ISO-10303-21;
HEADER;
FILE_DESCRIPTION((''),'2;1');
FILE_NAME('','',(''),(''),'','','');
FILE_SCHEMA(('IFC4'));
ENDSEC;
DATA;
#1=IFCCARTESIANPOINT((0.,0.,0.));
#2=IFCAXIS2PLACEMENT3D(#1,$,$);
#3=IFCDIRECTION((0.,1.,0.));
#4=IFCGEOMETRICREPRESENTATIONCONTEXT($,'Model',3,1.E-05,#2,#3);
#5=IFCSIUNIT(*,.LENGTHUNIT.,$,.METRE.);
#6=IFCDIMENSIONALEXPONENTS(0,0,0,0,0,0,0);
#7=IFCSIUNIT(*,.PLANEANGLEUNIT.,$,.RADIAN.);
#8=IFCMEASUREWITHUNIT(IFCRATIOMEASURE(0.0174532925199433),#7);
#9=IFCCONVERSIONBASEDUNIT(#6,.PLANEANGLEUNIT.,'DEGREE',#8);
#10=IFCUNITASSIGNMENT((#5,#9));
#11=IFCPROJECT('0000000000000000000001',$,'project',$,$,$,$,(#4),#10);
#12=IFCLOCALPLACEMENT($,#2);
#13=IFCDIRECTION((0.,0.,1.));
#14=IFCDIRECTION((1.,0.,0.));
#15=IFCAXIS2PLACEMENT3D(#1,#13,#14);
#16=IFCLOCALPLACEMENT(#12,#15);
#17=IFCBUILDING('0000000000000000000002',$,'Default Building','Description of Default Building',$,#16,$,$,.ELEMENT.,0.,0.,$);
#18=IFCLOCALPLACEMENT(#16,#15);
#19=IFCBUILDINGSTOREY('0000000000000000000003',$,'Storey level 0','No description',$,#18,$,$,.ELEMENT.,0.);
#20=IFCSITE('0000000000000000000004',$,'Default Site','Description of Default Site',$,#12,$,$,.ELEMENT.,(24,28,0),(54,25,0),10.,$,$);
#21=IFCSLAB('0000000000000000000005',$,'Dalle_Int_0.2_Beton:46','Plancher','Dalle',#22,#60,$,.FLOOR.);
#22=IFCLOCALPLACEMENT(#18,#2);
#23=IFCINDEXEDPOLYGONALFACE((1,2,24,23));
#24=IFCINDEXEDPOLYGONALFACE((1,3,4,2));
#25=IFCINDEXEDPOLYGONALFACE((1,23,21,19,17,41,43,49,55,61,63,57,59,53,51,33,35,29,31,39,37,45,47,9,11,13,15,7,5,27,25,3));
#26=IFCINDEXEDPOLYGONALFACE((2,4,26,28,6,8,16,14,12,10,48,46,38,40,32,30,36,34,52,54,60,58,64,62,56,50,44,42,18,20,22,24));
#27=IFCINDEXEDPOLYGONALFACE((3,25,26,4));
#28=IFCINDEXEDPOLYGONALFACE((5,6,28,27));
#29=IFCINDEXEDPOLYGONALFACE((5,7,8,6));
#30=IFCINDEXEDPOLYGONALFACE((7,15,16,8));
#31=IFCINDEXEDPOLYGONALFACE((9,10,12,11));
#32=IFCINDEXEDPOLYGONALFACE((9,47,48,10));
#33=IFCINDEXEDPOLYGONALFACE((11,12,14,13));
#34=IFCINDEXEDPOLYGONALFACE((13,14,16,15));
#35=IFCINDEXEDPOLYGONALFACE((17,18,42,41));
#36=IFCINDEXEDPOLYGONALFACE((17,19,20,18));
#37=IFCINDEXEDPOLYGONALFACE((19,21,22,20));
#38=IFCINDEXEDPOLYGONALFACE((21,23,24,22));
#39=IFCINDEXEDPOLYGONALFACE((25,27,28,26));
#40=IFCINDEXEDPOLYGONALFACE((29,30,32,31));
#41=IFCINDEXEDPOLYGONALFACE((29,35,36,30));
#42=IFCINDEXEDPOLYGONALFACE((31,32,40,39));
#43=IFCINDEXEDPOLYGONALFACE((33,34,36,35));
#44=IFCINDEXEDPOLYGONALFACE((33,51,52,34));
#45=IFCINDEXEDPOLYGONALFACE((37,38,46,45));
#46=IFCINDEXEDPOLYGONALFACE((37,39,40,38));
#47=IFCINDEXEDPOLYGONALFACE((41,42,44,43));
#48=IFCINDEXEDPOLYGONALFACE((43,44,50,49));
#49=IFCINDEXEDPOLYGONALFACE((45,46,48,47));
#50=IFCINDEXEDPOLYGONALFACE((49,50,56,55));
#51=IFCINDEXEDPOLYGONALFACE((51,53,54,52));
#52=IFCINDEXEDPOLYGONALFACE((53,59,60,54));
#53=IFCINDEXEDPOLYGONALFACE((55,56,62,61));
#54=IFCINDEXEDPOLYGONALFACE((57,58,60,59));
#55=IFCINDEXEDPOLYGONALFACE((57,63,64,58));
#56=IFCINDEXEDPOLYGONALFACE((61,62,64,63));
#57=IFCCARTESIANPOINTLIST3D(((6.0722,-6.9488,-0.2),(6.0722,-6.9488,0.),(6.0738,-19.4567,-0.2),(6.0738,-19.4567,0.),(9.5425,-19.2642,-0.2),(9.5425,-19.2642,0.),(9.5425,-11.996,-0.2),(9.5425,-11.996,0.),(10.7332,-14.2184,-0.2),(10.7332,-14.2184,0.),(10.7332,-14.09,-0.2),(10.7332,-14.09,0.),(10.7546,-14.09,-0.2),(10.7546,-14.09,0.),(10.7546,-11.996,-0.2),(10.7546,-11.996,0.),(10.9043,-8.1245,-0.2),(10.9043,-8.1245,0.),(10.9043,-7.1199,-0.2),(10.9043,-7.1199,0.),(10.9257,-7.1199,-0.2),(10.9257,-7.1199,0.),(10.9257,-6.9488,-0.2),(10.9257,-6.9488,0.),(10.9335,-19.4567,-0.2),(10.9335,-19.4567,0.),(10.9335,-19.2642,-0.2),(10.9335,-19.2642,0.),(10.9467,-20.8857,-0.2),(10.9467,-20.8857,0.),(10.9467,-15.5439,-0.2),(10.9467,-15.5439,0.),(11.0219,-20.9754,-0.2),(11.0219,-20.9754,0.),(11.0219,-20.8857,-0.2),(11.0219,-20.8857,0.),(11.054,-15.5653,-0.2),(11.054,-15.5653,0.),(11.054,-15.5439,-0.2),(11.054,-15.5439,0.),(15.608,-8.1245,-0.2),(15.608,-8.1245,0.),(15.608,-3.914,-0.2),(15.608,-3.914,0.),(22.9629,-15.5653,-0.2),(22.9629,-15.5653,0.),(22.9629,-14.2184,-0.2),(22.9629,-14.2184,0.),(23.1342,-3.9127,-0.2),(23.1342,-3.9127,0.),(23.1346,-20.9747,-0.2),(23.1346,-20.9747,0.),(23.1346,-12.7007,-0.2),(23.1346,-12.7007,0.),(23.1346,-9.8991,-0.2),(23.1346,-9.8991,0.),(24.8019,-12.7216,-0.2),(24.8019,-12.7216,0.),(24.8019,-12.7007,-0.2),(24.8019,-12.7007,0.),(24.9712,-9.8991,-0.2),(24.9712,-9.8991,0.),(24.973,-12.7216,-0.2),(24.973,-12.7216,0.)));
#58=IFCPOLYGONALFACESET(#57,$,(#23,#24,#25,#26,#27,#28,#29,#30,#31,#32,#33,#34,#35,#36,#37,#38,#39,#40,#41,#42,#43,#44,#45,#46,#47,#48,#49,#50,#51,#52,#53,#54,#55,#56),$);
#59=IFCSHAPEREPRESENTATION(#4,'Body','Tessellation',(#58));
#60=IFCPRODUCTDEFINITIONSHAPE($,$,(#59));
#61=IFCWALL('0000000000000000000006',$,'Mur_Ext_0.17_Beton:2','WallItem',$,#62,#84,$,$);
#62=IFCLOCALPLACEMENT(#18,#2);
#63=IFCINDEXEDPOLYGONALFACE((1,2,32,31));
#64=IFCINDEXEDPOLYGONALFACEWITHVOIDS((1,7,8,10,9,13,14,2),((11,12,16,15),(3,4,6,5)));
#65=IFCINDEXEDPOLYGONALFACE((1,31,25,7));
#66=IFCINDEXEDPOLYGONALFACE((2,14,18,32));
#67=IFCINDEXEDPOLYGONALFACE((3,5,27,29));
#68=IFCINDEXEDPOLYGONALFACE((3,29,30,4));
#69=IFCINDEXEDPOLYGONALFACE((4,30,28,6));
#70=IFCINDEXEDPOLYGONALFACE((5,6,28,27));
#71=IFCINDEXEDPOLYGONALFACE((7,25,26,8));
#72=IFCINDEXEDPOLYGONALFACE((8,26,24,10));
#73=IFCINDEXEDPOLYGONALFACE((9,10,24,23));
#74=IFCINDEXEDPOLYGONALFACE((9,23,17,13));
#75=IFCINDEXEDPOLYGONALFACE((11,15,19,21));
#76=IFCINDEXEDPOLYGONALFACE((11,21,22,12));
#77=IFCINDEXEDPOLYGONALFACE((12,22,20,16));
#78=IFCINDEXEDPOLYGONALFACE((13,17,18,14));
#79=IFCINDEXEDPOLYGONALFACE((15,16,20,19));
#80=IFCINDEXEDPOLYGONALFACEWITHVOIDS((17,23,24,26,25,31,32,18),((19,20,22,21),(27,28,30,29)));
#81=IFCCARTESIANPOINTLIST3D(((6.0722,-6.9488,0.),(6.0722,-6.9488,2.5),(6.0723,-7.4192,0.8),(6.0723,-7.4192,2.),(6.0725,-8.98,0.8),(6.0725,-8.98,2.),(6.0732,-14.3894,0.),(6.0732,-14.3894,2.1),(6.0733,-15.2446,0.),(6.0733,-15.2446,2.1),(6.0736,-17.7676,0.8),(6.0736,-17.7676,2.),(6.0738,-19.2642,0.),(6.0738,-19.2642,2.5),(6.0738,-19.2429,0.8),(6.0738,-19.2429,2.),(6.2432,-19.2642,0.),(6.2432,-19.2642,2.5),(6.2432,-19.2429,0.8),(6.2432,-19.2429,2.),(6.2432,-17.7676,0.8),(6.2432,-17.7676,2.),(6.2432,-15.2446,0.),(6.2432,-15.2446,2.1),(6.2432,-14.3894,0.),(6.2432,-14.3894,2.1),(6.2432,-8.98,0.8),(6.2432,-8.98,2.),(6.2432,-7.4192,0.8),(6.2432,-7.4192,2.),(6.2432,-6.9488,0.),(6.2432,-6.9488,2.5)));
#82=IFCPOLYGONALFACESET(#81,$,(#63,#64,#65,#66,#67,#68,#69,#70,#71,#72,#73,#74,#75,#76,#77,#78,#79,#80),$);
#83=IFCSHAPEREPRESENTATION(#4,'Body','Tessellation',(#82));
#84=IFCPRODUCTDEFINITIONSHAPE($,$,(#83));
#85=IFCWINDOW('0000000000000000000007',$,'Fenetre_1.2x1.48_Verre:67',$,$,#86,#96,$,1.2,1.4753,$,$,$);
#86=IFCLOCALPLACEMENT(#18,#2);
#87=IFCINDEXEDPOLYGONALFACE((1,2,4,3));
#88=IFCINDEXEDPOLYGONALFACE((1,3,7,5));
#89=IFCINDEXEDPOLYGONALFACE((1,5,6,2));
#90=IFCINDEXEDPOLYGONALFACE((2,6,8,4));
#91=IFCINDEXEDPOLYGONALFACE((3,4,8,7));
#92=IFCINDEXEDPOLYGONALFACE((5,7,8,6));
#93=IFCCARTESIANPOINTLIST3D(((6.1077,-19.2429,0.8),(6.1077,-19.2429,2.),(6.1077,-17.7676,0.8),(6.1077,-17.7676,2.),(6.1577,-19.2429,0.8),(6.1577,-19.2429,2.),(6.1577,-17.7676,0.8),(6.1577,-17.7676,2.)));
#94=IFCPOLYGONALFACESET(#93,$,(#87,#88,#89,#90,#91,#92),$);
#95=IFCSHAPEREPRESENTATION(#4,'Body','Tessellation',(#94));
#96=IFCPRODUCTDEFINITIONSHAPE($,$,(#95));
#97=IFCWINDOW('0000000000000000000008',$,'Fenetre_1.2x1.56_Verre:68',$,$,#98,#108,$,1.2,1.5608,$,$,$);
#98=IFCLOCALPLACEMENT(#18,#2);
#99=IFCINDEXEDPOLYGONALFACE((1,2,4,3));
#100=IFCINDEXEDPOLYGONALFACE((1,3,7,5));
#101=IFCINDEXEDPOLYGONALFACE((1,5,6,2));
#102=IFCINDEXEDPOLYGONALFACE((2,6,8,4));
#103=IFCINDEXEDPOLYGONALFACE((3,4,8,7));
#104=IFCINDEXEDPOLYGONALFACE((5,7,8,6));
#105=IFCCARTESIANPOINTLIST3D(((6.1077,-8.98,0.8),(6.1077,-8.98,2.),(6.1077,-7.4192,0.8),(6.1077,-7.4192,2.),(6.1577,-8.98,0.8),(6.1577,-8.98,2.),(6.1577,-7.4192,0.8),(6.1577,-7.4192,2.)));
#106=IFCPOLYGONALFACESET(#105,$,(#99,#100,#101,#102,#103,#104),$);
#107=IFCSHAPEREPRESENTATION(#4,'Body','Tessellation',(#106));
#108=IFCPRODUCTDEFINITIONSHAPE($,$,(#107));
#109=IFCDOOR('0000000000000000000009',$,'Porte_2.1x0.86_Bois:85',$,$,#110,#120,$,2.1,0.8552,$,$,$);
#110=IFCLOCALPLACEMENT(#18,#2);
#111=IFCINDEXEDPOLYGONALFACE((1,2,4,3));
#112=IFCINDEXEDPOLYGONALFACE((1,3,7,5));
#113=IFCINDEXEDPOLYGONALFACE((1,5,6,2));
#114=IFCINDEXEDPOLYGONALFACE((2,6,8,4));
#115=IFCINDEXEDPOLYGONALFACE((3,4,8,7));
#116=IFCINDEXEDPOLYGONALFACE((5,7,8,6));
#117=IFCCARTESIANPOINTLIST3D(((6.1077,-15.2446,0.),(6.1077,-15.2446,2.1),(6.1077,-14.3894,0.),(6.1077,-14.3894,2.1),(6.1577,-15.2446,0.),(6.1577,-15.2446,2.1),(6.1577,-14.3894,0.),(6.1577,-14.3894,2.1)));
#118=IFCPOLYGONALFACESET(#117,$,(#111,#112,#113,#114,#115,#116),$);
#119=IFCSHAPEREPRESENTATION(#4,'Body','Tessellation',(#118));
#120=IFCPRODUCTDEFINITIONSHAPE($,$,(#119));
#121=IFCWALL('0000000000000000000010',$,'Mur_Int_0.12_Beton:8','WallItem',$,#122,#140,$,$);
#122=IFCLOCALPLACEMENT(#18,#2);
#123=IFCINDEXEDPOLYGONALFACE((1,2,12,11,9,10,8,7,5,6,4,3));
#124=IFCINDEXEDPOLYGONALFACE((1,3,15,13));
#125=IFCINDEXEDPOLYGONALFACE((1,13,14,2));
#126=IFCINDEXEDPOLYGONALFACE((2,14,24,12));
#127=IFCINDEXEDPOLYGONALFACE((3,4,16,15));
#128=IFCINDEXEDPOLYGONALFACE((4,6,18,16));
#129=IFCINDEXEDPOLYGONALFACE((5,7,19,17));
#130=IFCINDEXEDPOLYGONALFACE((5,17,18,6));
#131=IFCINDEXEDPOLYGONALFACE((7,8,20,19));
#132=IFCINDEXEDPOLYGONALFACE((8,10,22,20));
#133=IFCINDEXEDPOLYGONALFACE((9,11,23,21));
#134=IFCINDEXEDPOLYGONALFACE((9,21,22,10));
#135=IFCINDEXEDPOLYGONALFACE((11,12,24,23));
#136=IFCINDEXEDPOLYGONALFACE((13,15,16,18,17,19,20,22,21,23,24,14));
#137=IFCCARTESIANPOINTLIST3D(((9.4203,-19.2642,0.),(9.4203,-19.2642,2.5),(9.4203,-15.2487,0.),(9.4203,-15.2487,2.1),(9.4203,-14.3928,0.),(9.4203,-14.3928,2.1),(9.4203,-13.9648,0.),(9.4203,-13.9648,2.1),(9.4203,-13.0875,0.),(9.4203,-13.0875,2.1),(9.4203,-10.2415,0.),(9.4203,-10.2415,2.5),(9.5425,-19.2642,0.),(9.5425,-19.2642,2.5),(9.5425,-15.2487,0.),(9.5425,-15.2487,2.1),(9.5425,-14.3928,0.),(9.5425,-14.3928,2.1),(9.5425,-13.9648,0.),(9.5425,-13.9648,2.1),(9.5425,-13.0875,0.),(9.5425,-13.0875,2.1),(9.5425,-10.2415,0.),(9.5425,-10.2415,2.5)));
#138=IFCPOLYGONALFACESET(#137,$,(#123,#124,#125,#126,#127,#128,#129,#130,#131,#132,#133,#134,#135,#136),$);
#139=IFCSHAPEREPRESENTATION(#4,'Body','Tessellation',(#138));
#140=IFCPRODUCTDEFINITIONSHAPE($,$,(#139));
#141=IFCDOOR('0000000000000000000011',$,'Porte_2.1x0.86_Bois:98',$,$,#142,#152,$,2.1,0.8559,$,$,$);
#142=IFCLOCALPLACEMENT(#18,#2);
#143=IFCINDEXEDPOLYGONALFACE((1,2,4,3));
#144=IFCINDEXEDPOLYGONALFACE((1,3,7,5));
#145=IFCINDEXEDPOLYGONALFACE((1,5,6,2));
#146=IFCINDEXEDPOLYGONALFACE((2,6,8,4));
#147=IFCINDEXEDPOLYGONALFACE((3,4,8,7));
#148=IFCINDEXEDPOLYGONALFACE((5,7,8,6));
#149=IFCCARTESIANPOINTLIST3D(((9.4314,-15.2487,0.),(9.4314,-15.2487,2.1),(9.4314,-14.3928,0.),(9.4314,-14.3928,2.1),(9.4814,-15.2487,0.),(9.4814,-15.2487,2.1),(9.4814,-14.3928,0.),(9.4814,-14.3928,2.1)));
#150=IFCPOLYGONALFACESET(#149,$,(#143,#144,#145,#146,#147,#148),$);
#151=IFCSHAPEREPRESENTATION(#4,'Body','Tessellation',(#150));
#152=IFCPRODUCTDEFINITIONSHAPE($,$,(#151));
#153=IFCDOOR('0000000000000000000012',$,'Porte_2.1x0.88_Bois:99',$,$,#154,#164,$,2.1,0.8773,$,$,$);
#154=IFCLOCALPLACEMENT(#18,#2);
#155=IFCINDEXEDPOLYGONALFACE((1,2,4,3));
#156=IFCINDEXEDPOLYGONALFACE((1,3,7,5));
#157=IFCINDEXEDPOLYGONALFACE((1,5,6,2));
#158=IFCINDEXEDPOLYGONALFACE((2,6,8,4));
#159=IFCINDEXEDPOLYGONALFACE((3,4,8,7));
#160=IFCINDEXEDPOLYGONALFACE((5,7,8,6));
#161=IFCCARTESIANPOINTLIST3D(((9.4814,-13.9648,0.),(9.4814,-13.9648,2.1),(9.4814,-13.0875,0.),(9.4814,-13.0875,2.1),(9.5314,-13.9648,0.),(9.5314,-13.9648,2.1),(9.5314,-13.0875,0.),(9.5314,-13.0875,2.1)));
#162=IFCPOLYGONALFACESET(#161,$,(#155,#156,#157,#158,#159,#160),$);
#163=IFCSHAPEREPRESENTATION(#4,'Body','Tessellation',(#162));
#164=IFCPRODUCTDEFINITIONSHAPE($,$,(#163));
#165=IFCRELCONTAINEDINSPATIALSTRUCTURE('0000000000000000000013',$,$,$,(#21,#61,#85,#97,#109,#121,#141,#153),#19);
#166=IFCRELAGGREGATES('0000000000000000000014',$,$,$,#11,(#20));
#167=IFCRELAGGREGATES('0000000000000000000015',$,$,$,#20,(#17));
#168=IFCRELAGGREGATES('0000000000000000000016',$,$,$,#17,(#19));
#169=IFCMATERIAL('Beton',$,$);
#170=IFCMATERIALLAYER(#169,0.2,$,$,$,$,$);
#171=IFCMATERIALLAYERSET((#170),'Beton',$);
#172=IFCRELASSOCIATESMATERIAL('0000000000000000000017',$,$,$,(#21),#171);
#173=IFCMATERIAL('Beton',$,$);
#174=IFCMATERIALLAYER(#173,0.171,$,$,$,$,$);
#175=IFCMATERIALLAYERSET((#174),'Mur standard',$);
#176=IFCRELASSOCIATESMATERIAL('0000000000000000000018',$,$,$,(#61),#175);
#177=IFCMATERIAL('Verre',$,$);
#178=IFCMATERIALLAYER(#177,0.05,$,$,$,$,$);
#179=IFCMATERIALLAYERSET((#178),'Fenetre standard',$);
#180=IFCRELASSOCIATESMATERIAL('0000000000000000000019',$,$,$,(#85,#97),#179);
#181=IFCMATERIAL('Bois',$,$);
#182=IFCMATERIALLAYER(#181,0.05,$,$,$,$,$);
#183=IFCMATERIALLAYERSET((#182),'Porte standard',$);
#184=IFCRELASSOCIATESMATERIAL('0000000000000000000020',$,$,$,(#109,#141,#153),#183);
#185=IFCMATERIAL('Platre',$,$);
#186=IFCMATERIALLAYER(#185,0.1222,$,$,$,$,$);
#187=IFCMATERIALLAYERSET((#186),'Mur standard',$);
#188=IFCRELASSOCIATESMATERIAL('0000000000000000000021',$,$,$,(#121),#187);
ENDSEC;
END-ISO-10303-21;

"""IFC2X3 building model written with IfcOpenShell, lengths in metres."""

from ifc_helpers import new_model, entity, si_unit, converted_unit, direction, frame, origin, origin_with_axes, place, context, project, spatial, polyline, outline, extrude, material, layer, layer_set, layer_usage, element, fill, save


model = new_model("IFC2X3")

# Units and contexts
model_context = context("Model", 3, precision=1e-05, world=origin(), true_north=direction((0.0, 1.0, 0.0)))
ifc_project = project(units=[si_unit("LENGTHUNIT", "METRE"), converted_unit("PLANEANGLEUNIT", "DEGREE", entity("IfcRatioMeasure", 0.0174532925199433), si_unit("PLANEANGLEUNIT", "RADIAN"), dimensions=[0, 0, 0, 0, 0, 0, 0])], contexts=[model_context])

# Site, building, storey
site_placement = place(None, origin())
site = spatial("IfcSite", under=ifc_project, at=site_placement, Name="Default Site", Description="Description of Default Site", CompositionType="ELEMENT", RefLatitude=(24, 28, 0), RefLongitude=(54, 25, 0), RefElevation=10.0)
building_placement = place(site_placement, origin_with_axes())
building = spatial("IfcBuilding", under=site, at=building_placement, Name="Default Building", Description="Description of Default Building", CompositionType="ELEMENT", ElevationOfRefHeight=0.0, ElevationOfTerrain=0.0)
storey_placement = place(building_placement, origin_with_axes())
storey = spatial("IfcBuildingStorey", under=building, at=storey_placement, Name="Storey level 0", Description="No description", CompositionType="ELEMENT", Elevation=0.0)

# Slab
ifc_material_1 = material(Name="Beton")
ifc_layer_1 = layer(ifc_material_1, 0.2)
ifc_layer_set_1 = layer_set([ifc_layer_1], Name="Beton")
ifc_layer_usage_1 = layer_usage(ifc_layer_set_1, "AXIS3", "POSITIVE", 0.2)
slab_placement = place(storey_placement, frame((0.0, 0.0, -0.2), z_axis=(0.0, 0.0, 1.0), x_axis=(1.0, 0.0, 0.0)))
element("IfcSlab", 1, at=slab_placement, inside=storey, material=ifc_layer_usage_1, Name="Dalle_Int_0.2_Beton:46", Description="Plancher", ObjectType="Dalle", PredefinedType="FLOOR", context=model_context, shape_type="SweptSolid", body=[
    extrude(outline(polyline([(23.1346, -9.8991), (24.9712, -9.8991), (24.973, -12.7216), (24.8019, -12.7216), (24.8019, -12.7007), (23.1346, -12.7007), (23.1346, -20.9747), (11.0219, -20.9754), (11.0219, -20.8857), (10.9467, -20.8857), (10.9467, -15.5439), (11.054, -15.5439), (11.054, -15.5653), (22.9629, -15.5653), (22.9629, -14.2184), (10.7332, -14.2184), (10.7332, -14.09), (10.7546, -14.09), (10.7546, -11.996), (9.5425, -11.996), (9.5425, -19.2642), (10.9335, -19.2642), (10.9335, -19.4567), (6.0738, -19.4567), (6.0722, -6.9488), (10.9257, -6.9488), (10.9257, -7.1199), (10.9043, -7.1199), (10.9043, -8.1245), (15.608, -8.1245), (15.608, -3.914), (23.1342, -3.9127), (23.1346, -9.8991)])), origin(), (0.0, 0.0, 1.0), 0.2),
])

# Wall, openings, windows, door
ifc_material_2 = material(Name="Beton")
ifc_layer_2 = layer(ifc_material_2, 0.171)
ifc_layer_set_2 = layer_set([ifc_layer_2], Name="Mur standard")
ifc_layer_usage_2 = layer_usage(ifc_layer_set_2, "AXIS2", "NEGATIVE", 0.171)
wall_1_placement = place(storey_placement, frame((6.1577, -6.9488, 0.0), z_axis=(0.0, 0.0, 1.0), x_axis=(0.0, -1.0, 0.0)))
wall_1 = element("IfcWall", 2, at=wall_1_placement, inside=storey, material=ifc_layer_usage_2, Name="Mur_Ext_0.17_Beton:2", Description="WallItem", context=model_context, shape_type="SweptSolid", body=[
    extrude(outline(polyline([(12.3154, 0.0855), (12.3154, -0.0839), (0.0, -0.0855), (0.0, 0.0855), (12.3154, 0.0855)])), origin(), (0.0, 0.0, 1.0), 2.5),
])
opening_1_placement = place(storey_placement, frame((6.0722, -17.7676, 0.8), z_axis=(0.0, 0.0, 1.0), x_axis=(0.0, -1.0, 0.0)))
opening_1 = element("IfcOpeningElement", 3, at=opening_1_placement, cuts=wall_1, context=model_context, shape_type="SweptSolid", body=[
    extrude(outline(polyline([(0.0, -0.05), (1.4753, -0.05), (1.4753, 0.221), (0.0, 0.221), (0.0, -0.05)])), origin(), (0.0, 0.0, 1.0), 1.2),
])
opening_2_placement = place(storey_placement, frame((6.0722, -7.4192, 0.8), z_axis=(0.0, 0.0, 1.0), x_axis=(0.0, -1.0, 0.0)))
opening_2 = element("IfcOpeningElement", 4, at=opening_2_placement, cuts=wall_1, context=model_context, shape_type="SweptSolid", body=[
    extrude(outline(polyline([(0.0, -0.05), (1.5608, -0.05), (1.5608, 0.221), (0.0, 0.221), (0.0, -0.05)])), origin(), (0.0, 0.0, 1.0), 1.2),
])
opening_3_placement = place(storey_placement, frame((6.0722, -14.3894, 0.0), z_axis=(0.0, 0.0, 1.0), x_axis=(0.0, -1.0, 0.0)))
opening_3 = element("IfcOpeningElement", 5, at=opening_3_placement, cuts=wall_1, context=model_context, shape_type="SweptSolid", body=[
    extrude(outline(polyline([(0.0, -0.05), (0.8552, -0.05), (0.8552, 0.221), (0.0, 0.221), (0.0, -0.05)])), origin(), (0.0, 0.0, 1.0), 2.1),
])
ifc_material_3 = material(Name="Verre")
ifc_layer_3 = layer(ifc_material_3, 0.05)
ifc_layer_set_3 = layer_set([ifc_layer_3], Name="Fenetre standard")
ifc_layer_usage_3 = layer_usage(ifc_layer_set_3, "AXIS2", "NEGATIVE", 0.05)
window_1_placement = place(wall_1_placement, frame((10.8188, 0.0, 0.8), z_axis=(0.0, 0.0, 1.0), x_axis=(1.0, 0.0, 0.0)))
window_1 = element("IfcWindow", 6, at=window_1_placement, inside=storey, material=ifc_layer_usage_3, Name="Fenetre_1.2x1.48_Verre:67", OverallHeight=1.2, OverallWidth=1.4753, context=model_context, shape_type="SweptSolid", body=[
    extrude(outline(polyline([(0.0, 0.0), (1.4753, 0.0), (1.4753, -0.05), (0.0, -0.05), (0.0, 0.0)])), origin(), (0.0, 0.0, 1.0), 1.2),
])
fill(opening_1, window_1)
window_2_placement = place(wall_1_placement, frame((0.4704, 0.0, 0.8), z_axis=(0.0, 0.0, 1.0), x_axis=(1.0, 0.0, 0.0)))
window_2 = element("IfcWindow", 7, at=window_2_placement, inside=storey, material=ifc_layer_usage_3, Name="Fenetre_1.2x1.56_Verre:68", OverallHeight=1.2, OverallWidth=1.5608, context=model_context, shape_type="SweptSolid", body=[
    extrude(outline(polyline([(0.0, 0.0), (1.5608, 0.0), (1.5608, -0.05), (0.0, -0.05), (0.0, 0.0)])), origin(), (0.0, 0.0, 1.0), 1.2),
])
fill(opening_2, window_2)
ifc_material_4 = material(Name="Bois")
ifc_layer_4 = layer(ifc_material_4, 0.05)
ifc_layer_set_4 = layer_set([ifc_layer_4], Name="Porte standard")
ifc_layer_usage_4 = layer_usage(ifc_layer_set_4, "AXIS2", "NEGATIVE", 0.05)
door_1_placement = place(wall_1_placement, frame((7.4406, 0.0, 0.0), z_axis=(0.0, 0.0, 1.0), x_axis=(1.0, 0.0, 0.0)))
door_1 = element("IfcDoor", 8, at=door_1_placement, inside=storey, material=ifc_layer_usage_4, Name="Porte_2.1x0.86_Bois:85", OverallHeight=2.1, OverallWidth=0.8552, context=model_context, shape_type="SweptSolid", body=[
    extrude(outline(polyline([(0.0, 0.0), (0.8552, 0.0), (0.8552, -0.05), (0.0, -0.05), (0.0, 0.0)])), origin(), (0.0, 0.0, 1.0), 2.1),
])
fill(opening_3, door_1)

# Wall, openings, doors
ifc_material_5 = material(Name="Platre")
ifc_layer_5 = layer(ifc_material_5, 0.1222)
ifc_layer_set_5 = layer_set([ifc_layer_5], Name="Mur standard")
ifc_layer_usage_5 = layer_usage(ifc_layer_set_5, "AXIS2", "NEGATIVE", 0.1222)
wall_2_placement = place(storey_placement, frame((9.4814, -10.2415, 0.0), z_axis=(0.0, 0.0, 1.0), x_axis=(0.0, -1.0, 0.0)))
wall_2 = element("IfcWall", 9, at=wall_2_placement, inside=storey, material=ifc_layer_usage_5, Name="Mur_Int_0.12_Beton:8", Description="WallItem", context=model_context, shape_type="SweptSolid", body=[
    extrude(outline(polyline([(0.0, -0.0611), (9.0227, -0.0611), (9.0227, 0.0611), (0.0, 0.0611), (0.0, -0.0611)])), origin(), (0.0, 0.0, 1.0), 2.5),
])
opening_4_placement = place(storey_placement, frame((9.4203, -14.3928, 0.0), z_axis=(0.0, 0.0, 1.0), x_axis=(0.0, -1.0, 0.0)))
opening_4 = element("IfcOpeningElement", 10, at=opening_4_placement, cuts=wall_2, context=model_context, shape_type="SweptSolid", body=[
    extrude(outline(polyline([(0.0, -0.05), (0.8559, -0.05), (0.8559, 0.1722), (0.0, 0.1722), (0.0, -0.05)])), origin(), (0.0, 0.0, 1.0), 2.1),
])
opening_5_placement = place(storey_placement, frame((9.4203, -13.9648, 0.0), z_axis=(0.0, 0.0, 1.0), x_axis=(0.0, 1.0, 0.0)))
opening_5 = element("IfcOpeningElement", 11, at=opening_5_placement, cuts=wall_2, context=model_context, shape_type="SweptSolid", body=[
    extrude(outline(polyline([(0.8773, 0.05), (0.0, 0.05), (0.0, -0.1722), (0.8773, -0.1722), (0.8773, 0.05)])), origin(), (0.0, 0.0, 1.0), 2.1),
])
door_2_placement = place(wall_2_placement, frame((4.1513, 0.0, 0.0), z_axis=(0.0, 0.0, 1.0), x_axis=(1.0, 0.0, 0.0)))
door_2 = element("IfcDoor", 12, at=door_2_placement, inside=storey, material=ifc_layer_usage_4, Name="Porte_2.1x0.86_Bois:98", OverallHeight=2.1, OverallWidth=0.8559, context=model_context, shape_type="SweptSolid", body=[
    extrude(outline(polyline([(0.0, 0.0), (0.8559, 0.0), (0.8559, -0.05), (0.0, -0.05), (0.0, 0.0)])), origin(), (0.0, 0.0, 1.0), 2.1),
])
fill(opening_4, door_2)
door_3_placement = place(wall_2_placement, frame((3.7233, 0.0, 0.0), z_axis=(0.0, 0.0, 1.0), x_axis=(-1.0, 0.0, 0.0)))
door_3 = element("IfcDoor", 13, at=door_3_placement, inside=storey, material=ifc_layer_usage_4, Name="Porte_2.1x0.88_Bois:99", OverallHeight=2.1, OverallWidth=0.8773, context=model_context, shape_type="SweptSolid", body=[
    extrude(outline(polyline([(0.0, 0.0), (0.8773, 0.0), (0.8773, -0.05), (0.0, -0.05), (0.0, 0.0)])), origin(), (0.0, 0.0, 1.0), 2.1),
])
fill(opening_5, door_3)

save(model, "model.ifc")
